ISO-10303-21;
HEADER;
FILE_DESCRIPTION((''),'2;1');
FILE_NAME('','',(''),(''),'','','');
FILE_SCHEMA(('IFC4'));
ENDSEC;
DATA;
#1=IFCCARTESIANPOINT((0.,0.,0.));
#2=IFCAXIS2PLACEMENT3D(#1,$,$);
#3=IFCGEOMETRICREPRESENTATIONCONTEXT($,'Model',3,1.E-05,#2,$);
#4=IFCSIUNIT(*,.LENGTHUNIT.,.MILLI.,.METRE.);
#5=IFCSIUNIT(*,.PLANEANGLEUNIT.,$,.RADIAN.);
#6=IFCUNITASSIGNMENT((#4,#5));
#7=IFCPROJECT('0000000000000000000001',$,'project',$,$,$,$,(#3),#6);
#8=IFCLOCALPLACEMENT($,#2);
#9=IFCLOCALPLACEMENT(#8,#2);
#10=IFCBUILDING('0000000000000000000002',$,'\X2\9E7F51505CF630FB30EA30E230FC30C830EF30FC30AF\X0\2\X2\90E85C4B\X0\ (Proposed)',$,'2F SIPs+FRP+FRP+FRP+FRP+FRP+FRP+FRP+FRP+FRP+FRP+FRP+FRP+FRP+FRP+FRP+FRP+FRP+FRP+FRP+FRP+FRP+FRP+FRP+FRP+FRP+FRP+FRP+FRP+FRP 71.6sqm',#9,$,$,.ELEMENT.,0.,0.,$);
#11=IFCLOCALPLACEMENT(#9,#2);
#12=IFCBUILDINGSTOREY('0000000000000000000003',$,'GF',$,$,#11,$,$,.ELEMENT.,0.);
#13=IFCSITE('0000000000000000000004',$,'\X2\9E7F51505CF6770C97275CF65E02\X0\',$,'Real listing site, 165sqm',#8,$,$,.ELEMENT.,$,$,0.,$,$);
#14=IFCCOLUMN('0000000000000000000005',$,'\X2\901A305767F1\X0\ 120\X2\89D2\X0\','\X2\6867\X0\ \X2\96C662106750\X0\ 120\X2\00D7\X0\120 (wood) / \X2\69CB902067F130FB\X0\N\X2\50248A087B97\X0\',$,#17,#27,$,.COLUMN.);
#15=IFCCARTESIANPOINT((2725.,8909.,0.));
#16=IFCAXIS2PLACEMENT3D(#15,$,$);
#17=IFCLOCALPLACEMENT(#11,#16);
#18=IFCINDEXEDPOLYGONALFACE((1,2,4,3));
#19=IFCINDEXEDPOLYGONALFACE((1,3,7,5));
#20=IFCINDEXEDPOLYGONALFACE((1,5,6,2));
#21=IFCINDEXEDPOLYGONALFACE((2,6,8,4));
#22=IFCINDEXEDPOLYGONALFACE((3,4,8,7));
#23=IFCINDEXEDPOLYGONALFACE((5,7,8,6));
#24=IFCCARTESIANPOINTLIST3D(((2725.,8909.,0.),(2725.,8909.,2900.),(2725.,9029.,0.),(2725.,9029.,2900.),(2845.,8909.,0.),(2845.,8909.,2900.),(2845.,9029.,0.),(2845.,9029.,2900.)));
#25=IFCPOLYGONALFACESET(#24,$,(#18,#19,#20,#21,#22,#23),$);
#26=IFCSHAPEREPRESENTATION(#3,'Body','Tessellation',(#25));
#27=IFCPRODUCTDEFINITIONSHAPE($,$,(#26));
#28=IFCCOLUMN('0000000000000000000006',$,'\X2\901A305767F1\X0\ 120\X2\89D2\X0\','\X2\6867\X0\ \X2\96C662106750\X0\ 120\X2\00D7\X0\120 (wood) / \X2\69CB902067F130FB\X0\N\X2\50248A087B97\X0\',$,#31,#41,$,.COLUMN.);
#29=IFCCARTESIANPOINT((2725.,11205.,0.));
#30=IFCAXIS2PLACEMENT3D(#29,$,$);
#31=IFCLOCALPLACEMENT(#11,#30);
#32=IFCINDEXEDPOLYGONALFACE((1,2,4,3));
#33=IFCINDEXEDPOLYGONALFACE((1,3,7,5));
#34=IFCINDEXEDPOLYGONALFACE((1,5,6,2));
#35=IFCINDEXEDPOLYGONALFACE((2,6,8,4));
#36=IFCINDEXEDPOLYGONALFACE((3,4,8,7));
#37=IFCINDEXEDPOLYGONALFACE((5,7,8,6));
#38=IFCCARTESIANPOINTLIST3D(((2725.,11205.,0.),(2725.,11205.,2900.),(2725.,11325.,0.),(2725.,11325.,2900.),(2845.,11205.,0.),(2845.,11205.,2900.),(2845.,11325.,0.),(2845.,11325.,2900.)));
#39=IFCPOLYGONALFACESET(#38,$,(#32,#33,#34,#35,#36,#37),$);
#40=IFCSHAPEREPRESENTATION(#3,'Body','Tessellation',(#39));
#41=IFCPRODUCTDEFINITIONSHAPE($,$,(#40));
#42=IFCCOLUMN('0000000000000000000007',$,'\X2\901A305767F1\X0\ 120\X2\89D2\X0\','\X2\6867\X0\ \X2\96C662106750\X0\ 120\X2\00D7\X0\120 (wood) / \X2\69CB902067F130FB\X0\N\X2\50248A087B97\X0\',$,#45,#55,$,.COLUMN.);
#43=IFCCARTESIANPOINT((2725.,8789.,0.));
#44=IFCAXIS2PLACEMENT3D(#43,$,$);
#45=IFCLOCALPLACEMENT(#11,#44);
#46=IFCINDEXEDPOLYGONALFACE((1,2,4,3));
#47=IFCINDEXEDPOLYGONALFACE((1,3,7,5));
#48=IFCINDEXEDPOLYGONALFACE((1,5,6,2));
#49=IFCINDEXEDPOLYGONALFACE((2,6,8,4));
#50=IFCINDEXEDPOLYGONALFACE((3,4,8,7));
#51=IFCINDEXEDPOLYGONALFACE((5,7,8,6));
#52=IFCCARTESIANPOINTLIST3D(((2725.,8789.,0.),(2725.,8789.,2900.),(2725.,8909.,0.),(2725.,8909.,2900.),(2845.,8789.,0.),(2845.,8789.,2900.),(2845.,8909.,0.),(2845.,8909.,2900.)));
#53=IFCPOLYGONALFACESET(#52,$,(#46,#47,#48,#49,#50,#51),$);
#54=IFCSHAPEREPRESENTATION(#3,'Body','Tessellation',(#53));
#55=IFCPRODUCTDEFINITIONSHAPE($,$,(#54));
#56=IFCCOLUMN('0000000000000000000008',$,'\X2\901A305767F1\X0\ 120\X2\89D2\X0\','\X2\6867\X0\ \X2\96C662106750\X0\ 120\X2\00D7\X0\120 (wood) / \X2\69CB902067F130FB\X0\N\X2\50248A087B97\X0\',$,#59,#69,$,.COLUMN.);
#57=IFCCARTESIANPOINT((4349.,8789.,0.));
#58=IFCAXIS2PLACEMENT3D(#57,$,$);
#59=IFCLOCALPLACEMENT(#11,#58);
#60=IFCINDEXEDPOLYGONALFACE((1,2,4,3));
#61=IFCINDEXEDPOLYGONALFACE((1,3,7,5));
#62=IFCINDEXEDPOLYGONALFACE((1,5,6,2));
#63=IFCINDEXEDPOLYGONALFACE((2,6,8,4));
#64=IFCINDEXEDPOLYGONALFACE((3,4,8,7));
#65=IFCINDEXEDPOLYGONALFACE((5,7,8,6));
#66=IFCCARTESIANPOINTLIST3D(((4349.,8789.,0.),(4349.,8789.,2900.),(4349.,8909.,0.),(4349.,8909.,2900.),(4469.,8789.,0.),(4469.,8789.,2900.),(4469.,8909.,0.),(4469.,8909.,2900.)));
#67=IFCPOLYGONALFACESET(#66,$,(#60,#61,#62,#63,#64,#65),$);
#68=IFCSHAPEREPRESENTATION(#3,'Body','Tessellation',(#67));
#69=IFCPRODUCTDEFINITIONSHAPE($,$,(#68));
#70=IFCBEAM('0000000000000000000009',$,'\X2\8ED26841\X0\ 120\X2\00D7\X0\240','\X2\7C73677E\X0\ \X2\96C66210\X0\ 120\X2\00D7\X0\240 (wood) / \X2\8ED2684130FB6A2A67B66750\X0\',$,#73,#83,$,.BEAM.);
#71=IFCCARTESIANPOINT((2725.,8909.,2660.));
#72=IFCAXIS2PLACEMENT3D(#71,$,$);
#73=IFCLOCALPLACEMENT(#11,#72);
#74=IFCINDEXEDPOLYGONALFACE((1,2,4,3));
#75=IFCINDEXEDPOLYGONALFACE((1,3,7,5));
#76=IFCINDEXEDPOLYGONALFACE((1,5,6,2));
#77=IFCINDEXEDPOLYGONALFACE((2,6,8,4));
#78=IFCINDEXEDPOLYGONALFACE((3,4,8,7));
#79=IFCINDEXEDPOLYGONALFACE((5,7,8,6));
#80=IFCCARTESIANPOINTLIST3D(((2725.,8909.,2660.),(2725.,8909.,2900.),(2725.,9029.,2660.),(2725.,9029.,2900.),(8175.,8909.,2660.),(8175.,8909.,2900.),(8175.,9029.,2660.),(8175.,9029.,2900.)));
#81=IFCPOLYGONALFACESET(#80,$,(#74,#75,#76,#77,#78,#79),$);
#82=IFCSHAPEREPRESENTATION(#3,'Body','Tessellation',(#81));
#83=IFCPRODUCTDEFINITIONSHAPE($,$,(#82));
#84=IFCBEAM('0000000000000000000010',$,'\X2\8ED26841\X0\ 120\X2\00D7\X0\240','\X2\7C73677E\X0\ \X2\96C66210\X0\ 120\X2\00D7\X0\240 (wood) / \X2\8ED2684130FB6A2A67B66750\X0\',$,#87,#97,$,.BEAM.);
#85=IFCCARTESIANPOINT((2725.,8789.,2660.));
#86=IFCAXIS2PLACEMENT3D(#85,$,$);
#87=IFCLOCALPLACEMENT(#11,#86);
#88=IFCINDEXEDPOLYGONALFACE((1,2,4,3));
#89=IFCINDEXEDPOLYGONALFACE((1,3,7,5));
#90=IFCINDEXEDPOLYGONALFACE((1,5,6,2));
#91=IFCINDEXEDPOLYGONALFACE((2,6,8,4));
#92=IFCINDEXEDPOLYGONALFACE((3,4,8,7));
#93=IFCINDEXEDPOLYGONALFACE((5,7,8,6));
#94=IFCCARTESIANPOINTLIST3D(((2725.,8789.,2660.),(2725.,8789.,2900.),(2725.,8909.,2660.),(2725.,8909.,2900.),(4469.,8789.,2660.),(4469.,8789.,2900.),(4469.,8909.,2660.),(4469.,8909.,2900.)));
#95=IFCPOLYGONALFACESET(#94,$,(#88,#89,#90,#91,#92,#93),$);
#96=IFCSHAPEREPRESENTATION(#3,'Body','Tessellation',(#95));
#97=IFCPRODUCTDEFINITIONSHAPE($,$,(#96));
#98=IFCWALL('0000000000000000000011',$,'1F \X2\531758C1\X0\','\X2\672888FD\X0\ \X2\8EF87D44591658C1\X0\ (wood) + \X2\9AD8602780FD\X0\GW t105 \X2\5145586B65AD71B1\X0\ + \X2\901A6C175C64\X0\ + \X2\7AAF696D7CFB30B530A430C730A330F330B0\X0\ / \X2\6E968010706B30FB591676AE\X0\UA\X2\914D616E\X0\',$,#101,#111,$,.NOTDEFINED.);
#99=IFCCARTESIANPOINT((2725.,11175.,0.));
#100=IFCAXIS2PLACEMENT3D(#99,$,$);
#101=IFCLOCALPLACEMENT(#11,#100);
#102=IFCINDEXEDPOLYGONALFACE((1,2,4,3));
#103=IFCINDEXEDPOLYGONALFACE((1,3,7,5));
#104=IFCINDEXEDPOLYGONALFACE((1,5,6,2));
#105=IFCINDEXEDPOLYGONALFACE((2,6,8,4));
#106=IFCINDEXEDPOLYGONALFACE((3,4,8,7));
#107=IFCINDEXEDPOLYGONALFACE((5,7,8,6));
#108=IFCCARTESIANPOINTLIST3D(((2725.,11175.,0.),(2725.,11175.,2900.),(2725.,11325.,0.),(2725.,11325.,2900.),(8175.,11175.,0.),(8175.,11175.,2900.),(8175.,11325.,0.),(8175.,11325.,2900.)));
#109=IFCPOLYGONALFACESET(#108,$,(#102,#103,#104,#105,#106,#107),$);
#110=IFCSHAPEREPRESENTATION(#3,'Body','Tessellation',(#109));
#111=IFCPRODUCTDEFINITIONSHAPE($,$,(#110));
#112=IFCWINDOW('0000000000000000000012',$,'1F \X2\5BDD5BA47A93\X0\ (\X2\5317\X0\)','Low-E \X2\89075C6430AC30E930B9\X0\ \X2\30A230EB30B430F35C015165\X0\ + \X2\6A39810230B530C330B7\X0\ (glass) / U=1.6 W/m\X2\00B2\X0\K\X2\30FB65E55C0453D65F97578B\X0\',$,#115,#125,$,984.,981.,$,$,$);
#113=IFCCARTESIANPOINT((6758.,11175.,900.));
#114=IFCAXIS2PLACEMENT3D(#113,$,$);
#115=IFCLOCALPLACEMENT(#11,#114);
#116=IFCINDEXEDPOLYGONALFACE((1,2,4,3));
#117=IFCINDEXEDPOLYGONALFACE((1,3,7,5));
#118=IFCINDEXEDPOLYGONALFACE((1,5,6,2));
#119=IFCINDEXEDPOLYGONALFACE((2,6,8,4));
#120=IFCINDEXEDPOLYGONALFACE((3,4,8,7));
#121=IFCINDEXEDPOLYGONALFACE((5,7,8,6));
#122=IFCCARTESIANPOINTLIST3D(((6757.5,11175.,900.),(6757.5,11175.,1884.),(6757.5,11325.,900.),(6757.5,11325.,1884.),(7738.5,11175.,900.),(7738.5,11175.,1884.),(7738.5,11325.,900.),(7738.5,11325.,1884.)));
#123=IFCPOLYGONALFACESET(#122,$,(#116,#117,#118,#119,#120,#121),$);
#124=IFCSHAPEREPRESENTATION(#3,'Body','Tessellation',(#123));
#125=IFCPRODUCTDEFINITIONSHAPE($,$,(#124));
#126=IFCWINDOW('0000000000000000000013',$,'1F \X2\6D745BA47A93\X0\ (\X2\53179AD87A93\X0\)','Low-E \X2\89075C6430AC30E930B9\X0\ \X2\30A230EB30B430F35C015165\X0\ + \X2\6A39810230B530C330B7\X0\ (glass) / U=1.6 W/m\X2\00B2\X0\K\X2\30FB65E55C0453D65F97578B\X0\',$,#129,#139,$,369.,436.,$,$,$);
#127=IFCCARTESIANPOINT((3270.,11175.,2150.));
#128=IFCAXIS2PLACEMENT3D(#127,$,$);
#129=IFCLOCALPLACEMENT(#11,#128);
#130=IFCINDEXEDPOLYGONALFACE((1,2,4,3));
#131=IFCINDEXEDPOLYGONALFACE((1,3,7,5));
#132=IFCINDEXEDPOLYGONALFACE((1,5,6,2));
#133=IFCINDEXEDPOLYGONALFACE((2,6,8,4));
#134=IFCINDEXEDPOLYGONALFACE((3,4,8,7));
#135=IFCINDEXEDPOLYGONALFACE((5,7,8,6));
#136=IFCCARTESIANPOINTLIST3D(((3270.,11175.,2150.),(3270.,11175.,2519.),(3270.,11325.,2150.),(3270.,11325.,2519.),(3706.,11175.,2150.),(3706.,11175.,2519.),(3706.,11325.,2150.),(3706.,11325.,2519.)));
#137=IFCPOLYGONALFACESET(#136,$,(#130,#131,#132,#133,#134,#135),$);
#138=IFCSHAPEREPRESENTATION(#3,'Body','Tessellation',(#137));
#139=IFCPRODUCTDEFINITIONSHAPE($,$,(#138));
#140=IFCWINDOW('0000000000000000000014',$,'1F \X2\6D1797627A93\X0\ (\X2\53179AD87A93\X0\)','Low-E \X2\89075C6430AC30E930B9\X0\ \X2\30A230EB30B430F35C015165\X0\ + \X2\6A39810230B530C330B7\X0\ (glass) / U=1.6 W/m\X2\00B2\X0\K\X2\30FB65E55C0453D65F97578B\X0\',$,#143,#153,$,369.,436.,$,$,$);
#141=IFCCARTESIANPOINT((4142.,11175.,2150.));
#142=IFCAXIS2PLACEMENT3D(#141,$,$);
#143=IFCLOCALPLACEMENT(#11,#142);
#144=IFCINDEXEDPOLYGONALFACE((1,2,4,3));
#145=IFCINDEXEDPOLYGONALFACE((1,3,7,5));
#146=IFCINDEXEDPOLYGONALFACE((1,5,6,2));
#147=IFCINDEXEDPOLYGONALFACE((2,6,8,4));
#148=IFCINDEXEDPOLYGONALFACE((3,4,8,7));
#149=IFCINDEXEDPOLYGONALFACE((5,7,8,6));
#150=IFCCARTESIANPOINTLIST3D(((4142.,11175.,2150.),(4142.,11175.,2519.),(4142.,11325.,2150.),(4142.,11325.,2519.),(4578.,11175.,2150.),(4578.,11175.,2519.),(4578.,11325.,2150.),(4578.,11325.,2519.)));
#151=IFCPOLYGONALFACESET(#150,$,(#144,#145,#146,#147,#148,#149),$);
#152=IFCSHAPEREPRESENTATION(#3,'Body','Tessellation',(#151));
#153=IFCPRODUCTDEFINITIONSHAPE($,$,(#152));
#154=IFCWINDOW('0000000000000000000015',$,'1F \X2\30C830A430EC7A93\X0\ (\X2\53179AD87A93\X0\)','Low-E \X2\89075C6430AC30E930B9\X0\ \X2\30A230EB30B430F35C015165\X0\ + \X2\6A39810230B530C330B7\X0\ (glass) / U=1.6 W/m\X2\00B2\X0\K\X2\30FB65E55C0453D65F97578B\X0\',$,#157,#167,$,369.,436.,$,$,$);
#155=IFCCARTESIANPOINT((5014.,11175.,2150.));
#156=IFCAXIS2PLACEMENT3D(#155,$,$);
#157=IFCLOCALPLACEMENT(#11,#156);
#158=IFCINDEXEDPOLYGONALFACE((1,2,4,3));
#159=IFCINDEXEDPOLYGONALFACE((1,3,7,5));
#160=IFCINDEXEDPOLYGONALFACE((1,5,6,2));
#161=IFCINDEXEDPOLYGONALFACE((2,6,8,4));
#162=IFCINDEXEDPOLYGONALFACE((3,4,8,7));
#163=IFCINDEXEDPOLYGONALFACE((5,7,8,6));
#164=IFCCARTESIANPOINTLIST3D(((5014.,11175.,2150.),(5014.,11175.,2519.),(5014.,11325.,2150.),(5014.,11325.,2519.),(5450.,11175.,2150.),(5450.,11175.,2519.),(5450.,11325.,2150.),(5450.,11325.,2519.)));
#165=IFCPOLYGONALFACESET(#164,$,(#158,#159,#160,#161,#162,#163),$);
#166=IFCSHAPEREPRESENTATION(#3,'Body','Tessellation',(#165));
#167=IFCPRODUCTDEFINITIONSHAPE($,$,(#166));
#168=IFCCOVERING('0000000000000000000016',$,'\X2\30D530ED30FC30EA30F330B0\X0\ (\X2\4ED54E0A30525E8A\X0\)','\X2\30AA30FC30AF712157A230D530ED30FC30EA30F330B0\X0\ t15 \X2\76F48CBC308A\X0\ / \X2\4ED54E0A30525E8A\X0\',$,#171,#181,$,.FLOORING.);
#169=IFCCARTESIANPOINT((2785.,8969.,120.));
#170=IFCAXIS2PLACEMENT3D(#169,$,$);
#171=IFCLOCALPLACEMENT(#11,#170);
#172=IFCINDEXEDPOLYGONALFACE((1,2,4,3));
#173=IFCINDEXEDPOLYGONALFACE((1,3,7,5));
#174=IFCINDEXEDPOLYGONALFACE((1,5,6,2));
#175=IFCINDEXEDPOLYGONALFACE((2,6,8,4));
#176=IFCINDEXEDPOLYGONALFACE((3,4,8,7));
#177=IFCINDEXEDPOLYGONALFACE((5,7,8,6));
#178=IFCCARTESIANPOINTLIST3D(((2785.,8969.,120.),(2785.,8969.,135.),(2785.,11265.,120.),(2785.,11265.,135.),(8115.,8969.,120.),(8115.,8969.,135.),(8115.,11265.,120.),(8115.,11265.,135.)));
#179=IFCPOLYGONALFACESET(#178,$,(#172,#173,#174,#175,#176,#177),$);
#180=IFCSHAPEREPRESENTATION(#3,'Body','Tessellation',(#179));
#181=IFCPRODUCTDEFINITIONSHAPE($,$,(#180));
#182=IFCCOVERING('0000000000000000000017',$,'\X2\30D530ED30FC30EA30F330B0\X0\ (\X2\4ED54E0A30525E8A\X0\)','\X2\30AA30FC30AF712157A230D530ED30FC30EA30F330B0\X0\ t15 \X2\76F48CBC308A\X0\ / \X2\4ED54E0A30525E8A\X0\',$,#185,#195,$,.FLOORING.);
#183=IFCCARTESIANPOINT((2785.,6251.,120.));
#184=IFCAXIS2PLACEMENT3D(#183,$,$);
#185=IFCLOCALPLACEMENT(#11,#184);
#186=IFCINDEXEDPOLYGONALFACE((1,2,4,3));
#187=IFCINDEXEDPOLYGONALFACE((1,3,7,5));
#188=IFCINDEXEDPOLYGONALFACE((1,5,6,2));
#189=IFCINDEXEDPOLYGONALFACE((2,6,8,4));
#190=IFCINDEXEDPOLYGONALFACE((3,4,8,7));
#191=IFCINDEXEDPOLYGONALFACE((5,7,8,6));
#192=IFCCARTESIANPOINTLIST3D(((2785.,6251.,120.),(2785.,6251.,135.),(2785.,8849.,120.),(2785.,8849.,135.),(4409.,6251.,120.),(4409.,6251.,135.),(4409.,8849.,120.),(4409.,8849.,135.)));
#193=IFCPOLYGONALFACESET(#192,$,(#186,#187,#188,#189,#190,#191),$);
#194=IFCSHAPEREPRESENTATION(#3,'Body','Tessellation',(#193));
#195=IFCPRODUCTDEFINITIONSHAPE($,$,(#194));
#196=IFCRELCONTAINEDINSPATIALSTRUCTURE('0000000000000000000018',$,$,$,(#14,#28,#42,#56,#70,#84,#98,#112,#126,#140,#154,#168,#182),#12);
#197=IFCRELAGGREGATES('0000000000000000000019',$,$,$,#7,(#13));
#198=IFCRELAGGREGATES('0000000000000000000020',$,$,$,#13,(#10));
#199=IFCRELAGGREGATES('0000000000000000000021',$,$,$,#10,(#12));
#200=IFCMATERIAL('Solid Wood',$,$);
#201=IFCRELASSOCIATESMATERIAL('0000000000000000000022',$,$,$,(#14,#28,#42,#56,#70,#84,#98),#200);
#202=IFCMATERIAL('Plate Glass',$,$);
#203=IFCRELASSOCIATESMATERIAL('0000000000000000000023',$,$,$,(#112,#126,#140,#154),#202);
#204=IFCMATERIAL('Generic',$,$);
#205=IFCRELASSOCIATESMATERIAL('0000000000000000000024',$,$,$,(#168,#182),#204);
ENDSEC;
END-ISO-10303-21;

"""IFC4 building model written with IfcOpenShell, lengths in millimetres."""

from ifc_helpers import new_model, si_unit, frame, frame_2d, origin, place, context, project, spatial, rectangle, extrude, material, element, fill, save


model = new_model("IFC4")

# Units and contexts
model_context = context("Model", 3, precision=1e-05, world=origin())
ifc_project = project(units=[si_unit("LENGTHUNIT", "METRE", prefix="MILLI"), si_unit("PLANEANGLEUNIT", "RADIAN")], contexts=[model_context])

# Site, building, storey
site_placement = place(None, origin())
site = spatial("IfcSite", under=ifc_project, at=site_placement, Name="鹿児島県霧島市", ObjectType="Real listing site, 165sqm", CompositionType="ELEMENT", RefElevation=0.0)
building_placement = place(site_placement, origin())
building = spatial("IfcBuilding", under=site, at=building_placement, Name="鹿児島・リモートワーク2部屋 (Proposed)", ObjectType="2F SIPs+FRP+FRP+FRP+FRP+FRP+FRP+FRP+FRP+FRP+FRP+FRP+FRP+FRP+FRP+FRP+FRP+FRP+FRP+FRP+FRP+FRP+FRP+FRP+FRP+FRP+FRP+FRP+FRP+FRP 71.6sqm", CompositionType="ELEMENT", ElevationOfRefHeight=0.0, ElevationOfTerrain=0.0)
storey_placement = place(building_placement, origin())
storey = spatial("IfcBuildingStorey", under=building, at=storey_placement, Name="GF", CompositionType="ELEMENT", Elevation=0.0)

# Columns
ifc_material_1 = material(Name="Solid Wood")
column_1_placement = place(storey_placement, frame((2725.0, 8909.0, 0.0)))
element("IfcColumn", 1, at=column_1_placement, inside=storey, material=ifc_material_1, Name="通し柱 120角", Description="桧 集成材 120×120 (wood) / 構造柱・N値計算", PredefinedType="COLUMN", context=model_context, shape_type="SweptSolid", body=[
    extrude(rectangle(XDim=120.0, YDim=120.0, at=frame_2d((60.0, 60.0))), frame((2725.0, 8909.0, 0.0)), (0.0, 0.0, 1.0), 2900.0),
])
column_2_placement = place(storey_placement, frame((2725.0, 11205.0, 0.0)))
element("IfcColumn", 2, at=column_2_placement, inside=storey, material=ifc_material_1, Name="通し柱 120角", Description="桧 集成材 120×120 (wood) / 構造柱・N値計算", PredefinedType="COLUMN", context=model_context, shape_type="SweptSolid", body=[
    extrude(rectangle(XDim=120.0, YDim=120.0, at=frame_2d((60.0, 60.0))), frame((2725.0, 11205.0, 0.0)), (0.0, 0.0, 1.0), 2900.0),
])
column_3_placement = place(storey_placement, frame((2725.0, 8789.0, 0.0)))
element("IfcColumn", 3, at=column_3_placement, inside=storey, material=ifc_material_1, Name="通し柱 120角", Description="桧 集成材 120×120 (wood) / 構造柱・N値計算", PredefinedType="COLUMN", context=model_context, shape_type="SweptSolid", body=[
    extrude(rectangle(XDim=120.0, YDim=120.0, at=frame_2d((60.0, 60.0))), frame((2725.0, 8789.0, 0.0)), (0.0, 0.0, 1.0), 2900.0),
])
column_4_placement = place(storey_placement, frame((4349.0, 8789.0, 0.0)))
element("IfcColumn", 4, at=column_4_placement, inside=storey, material=ifc_material_1, Name="通し柱 120角", Description="桧 集成材 120×120 (wood) / 構造柱・N値計算", PredefinedType="COLUMN", context=model_context, shape_type="SweptSolid", body=[
    extrude(rectangle(XDim=120.0, YDim=120.0, at=frame_2d((60.0, 60.0))), frame((4349.0, 8789.0, 0.0)), (0.0, 0.0, 1.0), 2900.0),
])

# Beams
beam_1_placement = place(storey_placement, frame((2725.0, 8909.0, 2660.0)))
element("IfcBeam", 5, at=beam_1_placement, inside=storey, material=ifc_material_1, Name="軒桁 120×240", Description="米松 集成 120×240 (wood) / 軒桁・横架材", PredefinedType="BEAM", context=model_context, shape_type="SweptSolid", body=[
    extrude(rectangle(XDim=5450.0, YDim=120.0, at=frame_2d((2725.0, 60.0))), frame((2725.0, 8909.0, 2660.0)), (0.0, 0.0, 1.0), 240.0),
])
beam_2_placement = place(storey_placement, frame((2725.0, 8789.0, 2660.0)))
element("IfcBeam", 6, at=beam_2_placement, inside=storey, material=ifc_material_1, Name="軒桁 120×240", Description="米松 集成 120×240 (wood) / 軒桁・横架材", PredefinedType="BEAM", context=model_context, shape_type="SweptSolid", body=[
    extrude(rectangle(XDim=1744.0, YDim=120.0, at=frame_2d((872.0, 60.0))), frame((2725.0, 8789.0, 2660.0)), (0.0, 0.0, 1.0), 240.0),
])

# Wall, openings, windows
wall_1_placement = place(storey_placement, frame((2725.0, 11175.0, 0.0)))
wall_1 = element("IfcWall", 7, at=wall_1_placement, inside=storey, material=ifc_material_1, Name="1F 北壁", Description="木製 軸組外壁 (wood) + 高性能GW t105 充填断熱 + 通気層 + 窯業系サイディング / 準耐火・外皮UA配慮", PredefinedType="NOTDEFINED", context=model_context, shape_type="SweptSolid", body=[
    extrude(rectangle(XDim=5450.0, YDim=150.0, at=frame_2d((2725.0, 75.0))), frame((2725.0, 11175.0, 0.0)), (0.0, 0.0, 1.0), 2900.0),
])
opening_1_placement = place(storey_placement, frame((6758.0, 11175.0, 900.0)))
opening_1 = element("IfcOpeningElement", 8, at=opening_1_placement, cuts=wall_1, PredefinedType="NOTDEFINED", context=model_context, shape_type="SweptSolid", body=[
    extrude(rectangle(XDim=981.0, YDim=150.0, at=frame_2d((490.0, 75.0))), frame((6758.0, 11175.0, 900.0)), (0.0, 0.0, 1.0), 984.0),
])
opening_2_placement = place(storey_placement, frame((3270.0, 11175.0, 2150.0)))
opening_2 = element("IfcOpeningElement", 9, at=opening_2_placement, cuts=wall_1, PredefinedType="NOTDEFINED", context=model_context, shape_type="SweptSolid", body=[
    extrude(rectangle(XDim=436.0, YDim=150.0, at=frame_2d((218.0, 75.0))), frame((3270.0, 11175.0, 2150.0)), (0.0, 0.0, 1.0), 369.0),
])
opening_3_placement = place(storey_placement, frame((4142.0, 11175.0, 2150.0)))
opening_3 = element("IfcOpeningElement", 10, at=opening_3_placement, cuts=wall_1, PredefinedType="NOTDEFINED", context=model_context, shape_type="SweptSolid", body=[
    extrude(rectangle(XDim=436.0, YDim=150.0, at=frame_2d((218.0, 75.0))), frame((4142.0, 11175.0, 2150.0)), (0.0, 0.0, 1.0), 369.0),
])
opening_4_placement = place(storey_placement, frame((5014.0, 11175.0, 2150.0)))
opening_4 = element("IfcOpeningElement", 11, at=opening_4_placement, cuts=wall_1, PredefinedType="NOTDEFINED", context=model_context, shape_type="SweptSolid", body=[
    extrude(rectangle(XDim=436.0, YDim=150.0, at=frame_2d((218.0, 75.0))), frame((5014.0, 11175.0, 2150.0)), (0.0, 0.0, 1.0), 369.0),
])
ifc_material_2 = material(Name="Plate Glass")
window_1_placement = place(storey_placement, frame((6758.0, 11175.0, 900.0)))
window_1 = element("IfcWindow", 12, at=window_1_placement, inside=storey, material=ifc_material_2, Name="1F 寝室窓 (北)", Description="Low-E 複層ガラス アルゴン封入 + 樹脂サッシ (glass) / U=1.6 W/m²K・日射取得型", OverallHeight=984.0, OverallWidth=981.0, context=model_context, shape_type="SweptSolid", body=[
    extrude(rectangle(XDim=981.0, YDim=150.0, at=frame_2d((490.0, 75.0))), frame((6758.0, 11175.0, 900.0)), (0.0, 0.0, 1.0), 984.0),
])
fill(opening_1, window_1)
window_2_placement = place(storey_placement, frame((3270.0, 11175.0, 2150.0)))
window_2 = element("IfcWindow", 13, at=window_2_placement, inside=storey, material=ifc_material_2, Name="1F 浴室窓 (北高窓)", Description="Low-E 複層ガラス アルゴン封入 + 樹脂サッシ (glass) / U=1.6 W/m²K・日射取得型", OverallHeight=369.0, OverallWidth=436.0, context=model_context, shape_type="SweptSolid", body=[
    extrude(rectangle(XDim=436.0, YDim=150.0, at=frame_2d((218.0, 75.0))), frame((3270.0, 11175.0, 2150.0)), (0.0, 0.0, 1.0), 369.0),
])
fill(opening_2, window_2)
window_3_placement = place(storey_placement, frame((4142.0, 11175.0, 2150.0)))
window_3 = element("IfcWindow", 14, at=window_3_placement, inside=storey, material=ifc_material_2, Name="1F 洗面窓 (北高窓)", Description="Low-E 複層ガラス アルゴン封入 + 樹脂サッシ (glass) / U=1.6 W/m²K・日射取得型", OverallHeight=369.0, OverallWidth=436.0, context=model_context, shape_type="SweptSolid", body=[
    extrude(rectangle(XDim=436.0, YDim=150.0, at=frame_2d((218.0, 75.0))), frame((4142.0, 11175.0, 2150.0)), (0.0, 0.0, 1.0), 369.0),
])
fill(opening_3, window_3)
window_4_placement = place(storey_placement, frame((5014.0, 11175.0, 2150.0)))
window_4 = element("IfcWindow", 15, at=window_4_placement, inside=storey, material=ifc_material_2, Name="1F トイレ窓 (北高窓)", Description="Low-E 複層ガラス アルゴン封入 + 樹脂サッシ (glass) / U=1.6 W/m²K・日射取得型", OverallHeight=369.0, OverallWidth=436.0, context=model_context, shape_type="SweptSolid", body=[
    extrude(rectangle(XDim=436.0, YDim=150.0, at=frame_2d((218.0, 75.0))), frame((5014.0, 11175.0, 2150.0)), (0.0, 0.0, 1.0), 369.0),
])
fill(opening_4, window_4)

# Coverings
ifc_material_3 = material(Name="Generic")
covering_1_placement = place(storey_placement, frame((2785.0, 8969.0, 120.0)))
element("IfcCovering", 16, at=covering_1_placement, inside=storey, material=ifc_material_3, Name="フローリング (仕上げ床)", Description="オーク無垢フローリング t15 直貼り / 仕上げ床", PredefinedType="FLOORING", context=model_context, shape_type="SweptSolid", body=[
    extrude(rectangle(XDim=5330.0, YDim=2296.0, at=frame_2d((2665.0, 1148.0))), frame((2785.0, 8969.0, 120.0)), (0.0, 0.0, 1.0), 15.0),
])
covering_2_placement = place(storey_placement, frame((2785.0, 6251.0, 120.0)))
element("IfcCovering", 17, at=covering_2_placement, inside=storey, material=ifc_material_3, Name="フローリング (仕上げ床)", Description="オーク無垢フローリング t15 直貼り / 仕上げ床", PredefinedType="FLOORING", context=model_context, shape_type="SweptSolid", body=[
    extrude(rectangle(XDim=1624.0, YDim=2598.0, at=frame_2d((812.0, 1299.0))), frame((2785.0, 6251.0, 120.0)), (0.0, 0.0, 1.0), 15.0),
])

save(model, "model.ifc")
